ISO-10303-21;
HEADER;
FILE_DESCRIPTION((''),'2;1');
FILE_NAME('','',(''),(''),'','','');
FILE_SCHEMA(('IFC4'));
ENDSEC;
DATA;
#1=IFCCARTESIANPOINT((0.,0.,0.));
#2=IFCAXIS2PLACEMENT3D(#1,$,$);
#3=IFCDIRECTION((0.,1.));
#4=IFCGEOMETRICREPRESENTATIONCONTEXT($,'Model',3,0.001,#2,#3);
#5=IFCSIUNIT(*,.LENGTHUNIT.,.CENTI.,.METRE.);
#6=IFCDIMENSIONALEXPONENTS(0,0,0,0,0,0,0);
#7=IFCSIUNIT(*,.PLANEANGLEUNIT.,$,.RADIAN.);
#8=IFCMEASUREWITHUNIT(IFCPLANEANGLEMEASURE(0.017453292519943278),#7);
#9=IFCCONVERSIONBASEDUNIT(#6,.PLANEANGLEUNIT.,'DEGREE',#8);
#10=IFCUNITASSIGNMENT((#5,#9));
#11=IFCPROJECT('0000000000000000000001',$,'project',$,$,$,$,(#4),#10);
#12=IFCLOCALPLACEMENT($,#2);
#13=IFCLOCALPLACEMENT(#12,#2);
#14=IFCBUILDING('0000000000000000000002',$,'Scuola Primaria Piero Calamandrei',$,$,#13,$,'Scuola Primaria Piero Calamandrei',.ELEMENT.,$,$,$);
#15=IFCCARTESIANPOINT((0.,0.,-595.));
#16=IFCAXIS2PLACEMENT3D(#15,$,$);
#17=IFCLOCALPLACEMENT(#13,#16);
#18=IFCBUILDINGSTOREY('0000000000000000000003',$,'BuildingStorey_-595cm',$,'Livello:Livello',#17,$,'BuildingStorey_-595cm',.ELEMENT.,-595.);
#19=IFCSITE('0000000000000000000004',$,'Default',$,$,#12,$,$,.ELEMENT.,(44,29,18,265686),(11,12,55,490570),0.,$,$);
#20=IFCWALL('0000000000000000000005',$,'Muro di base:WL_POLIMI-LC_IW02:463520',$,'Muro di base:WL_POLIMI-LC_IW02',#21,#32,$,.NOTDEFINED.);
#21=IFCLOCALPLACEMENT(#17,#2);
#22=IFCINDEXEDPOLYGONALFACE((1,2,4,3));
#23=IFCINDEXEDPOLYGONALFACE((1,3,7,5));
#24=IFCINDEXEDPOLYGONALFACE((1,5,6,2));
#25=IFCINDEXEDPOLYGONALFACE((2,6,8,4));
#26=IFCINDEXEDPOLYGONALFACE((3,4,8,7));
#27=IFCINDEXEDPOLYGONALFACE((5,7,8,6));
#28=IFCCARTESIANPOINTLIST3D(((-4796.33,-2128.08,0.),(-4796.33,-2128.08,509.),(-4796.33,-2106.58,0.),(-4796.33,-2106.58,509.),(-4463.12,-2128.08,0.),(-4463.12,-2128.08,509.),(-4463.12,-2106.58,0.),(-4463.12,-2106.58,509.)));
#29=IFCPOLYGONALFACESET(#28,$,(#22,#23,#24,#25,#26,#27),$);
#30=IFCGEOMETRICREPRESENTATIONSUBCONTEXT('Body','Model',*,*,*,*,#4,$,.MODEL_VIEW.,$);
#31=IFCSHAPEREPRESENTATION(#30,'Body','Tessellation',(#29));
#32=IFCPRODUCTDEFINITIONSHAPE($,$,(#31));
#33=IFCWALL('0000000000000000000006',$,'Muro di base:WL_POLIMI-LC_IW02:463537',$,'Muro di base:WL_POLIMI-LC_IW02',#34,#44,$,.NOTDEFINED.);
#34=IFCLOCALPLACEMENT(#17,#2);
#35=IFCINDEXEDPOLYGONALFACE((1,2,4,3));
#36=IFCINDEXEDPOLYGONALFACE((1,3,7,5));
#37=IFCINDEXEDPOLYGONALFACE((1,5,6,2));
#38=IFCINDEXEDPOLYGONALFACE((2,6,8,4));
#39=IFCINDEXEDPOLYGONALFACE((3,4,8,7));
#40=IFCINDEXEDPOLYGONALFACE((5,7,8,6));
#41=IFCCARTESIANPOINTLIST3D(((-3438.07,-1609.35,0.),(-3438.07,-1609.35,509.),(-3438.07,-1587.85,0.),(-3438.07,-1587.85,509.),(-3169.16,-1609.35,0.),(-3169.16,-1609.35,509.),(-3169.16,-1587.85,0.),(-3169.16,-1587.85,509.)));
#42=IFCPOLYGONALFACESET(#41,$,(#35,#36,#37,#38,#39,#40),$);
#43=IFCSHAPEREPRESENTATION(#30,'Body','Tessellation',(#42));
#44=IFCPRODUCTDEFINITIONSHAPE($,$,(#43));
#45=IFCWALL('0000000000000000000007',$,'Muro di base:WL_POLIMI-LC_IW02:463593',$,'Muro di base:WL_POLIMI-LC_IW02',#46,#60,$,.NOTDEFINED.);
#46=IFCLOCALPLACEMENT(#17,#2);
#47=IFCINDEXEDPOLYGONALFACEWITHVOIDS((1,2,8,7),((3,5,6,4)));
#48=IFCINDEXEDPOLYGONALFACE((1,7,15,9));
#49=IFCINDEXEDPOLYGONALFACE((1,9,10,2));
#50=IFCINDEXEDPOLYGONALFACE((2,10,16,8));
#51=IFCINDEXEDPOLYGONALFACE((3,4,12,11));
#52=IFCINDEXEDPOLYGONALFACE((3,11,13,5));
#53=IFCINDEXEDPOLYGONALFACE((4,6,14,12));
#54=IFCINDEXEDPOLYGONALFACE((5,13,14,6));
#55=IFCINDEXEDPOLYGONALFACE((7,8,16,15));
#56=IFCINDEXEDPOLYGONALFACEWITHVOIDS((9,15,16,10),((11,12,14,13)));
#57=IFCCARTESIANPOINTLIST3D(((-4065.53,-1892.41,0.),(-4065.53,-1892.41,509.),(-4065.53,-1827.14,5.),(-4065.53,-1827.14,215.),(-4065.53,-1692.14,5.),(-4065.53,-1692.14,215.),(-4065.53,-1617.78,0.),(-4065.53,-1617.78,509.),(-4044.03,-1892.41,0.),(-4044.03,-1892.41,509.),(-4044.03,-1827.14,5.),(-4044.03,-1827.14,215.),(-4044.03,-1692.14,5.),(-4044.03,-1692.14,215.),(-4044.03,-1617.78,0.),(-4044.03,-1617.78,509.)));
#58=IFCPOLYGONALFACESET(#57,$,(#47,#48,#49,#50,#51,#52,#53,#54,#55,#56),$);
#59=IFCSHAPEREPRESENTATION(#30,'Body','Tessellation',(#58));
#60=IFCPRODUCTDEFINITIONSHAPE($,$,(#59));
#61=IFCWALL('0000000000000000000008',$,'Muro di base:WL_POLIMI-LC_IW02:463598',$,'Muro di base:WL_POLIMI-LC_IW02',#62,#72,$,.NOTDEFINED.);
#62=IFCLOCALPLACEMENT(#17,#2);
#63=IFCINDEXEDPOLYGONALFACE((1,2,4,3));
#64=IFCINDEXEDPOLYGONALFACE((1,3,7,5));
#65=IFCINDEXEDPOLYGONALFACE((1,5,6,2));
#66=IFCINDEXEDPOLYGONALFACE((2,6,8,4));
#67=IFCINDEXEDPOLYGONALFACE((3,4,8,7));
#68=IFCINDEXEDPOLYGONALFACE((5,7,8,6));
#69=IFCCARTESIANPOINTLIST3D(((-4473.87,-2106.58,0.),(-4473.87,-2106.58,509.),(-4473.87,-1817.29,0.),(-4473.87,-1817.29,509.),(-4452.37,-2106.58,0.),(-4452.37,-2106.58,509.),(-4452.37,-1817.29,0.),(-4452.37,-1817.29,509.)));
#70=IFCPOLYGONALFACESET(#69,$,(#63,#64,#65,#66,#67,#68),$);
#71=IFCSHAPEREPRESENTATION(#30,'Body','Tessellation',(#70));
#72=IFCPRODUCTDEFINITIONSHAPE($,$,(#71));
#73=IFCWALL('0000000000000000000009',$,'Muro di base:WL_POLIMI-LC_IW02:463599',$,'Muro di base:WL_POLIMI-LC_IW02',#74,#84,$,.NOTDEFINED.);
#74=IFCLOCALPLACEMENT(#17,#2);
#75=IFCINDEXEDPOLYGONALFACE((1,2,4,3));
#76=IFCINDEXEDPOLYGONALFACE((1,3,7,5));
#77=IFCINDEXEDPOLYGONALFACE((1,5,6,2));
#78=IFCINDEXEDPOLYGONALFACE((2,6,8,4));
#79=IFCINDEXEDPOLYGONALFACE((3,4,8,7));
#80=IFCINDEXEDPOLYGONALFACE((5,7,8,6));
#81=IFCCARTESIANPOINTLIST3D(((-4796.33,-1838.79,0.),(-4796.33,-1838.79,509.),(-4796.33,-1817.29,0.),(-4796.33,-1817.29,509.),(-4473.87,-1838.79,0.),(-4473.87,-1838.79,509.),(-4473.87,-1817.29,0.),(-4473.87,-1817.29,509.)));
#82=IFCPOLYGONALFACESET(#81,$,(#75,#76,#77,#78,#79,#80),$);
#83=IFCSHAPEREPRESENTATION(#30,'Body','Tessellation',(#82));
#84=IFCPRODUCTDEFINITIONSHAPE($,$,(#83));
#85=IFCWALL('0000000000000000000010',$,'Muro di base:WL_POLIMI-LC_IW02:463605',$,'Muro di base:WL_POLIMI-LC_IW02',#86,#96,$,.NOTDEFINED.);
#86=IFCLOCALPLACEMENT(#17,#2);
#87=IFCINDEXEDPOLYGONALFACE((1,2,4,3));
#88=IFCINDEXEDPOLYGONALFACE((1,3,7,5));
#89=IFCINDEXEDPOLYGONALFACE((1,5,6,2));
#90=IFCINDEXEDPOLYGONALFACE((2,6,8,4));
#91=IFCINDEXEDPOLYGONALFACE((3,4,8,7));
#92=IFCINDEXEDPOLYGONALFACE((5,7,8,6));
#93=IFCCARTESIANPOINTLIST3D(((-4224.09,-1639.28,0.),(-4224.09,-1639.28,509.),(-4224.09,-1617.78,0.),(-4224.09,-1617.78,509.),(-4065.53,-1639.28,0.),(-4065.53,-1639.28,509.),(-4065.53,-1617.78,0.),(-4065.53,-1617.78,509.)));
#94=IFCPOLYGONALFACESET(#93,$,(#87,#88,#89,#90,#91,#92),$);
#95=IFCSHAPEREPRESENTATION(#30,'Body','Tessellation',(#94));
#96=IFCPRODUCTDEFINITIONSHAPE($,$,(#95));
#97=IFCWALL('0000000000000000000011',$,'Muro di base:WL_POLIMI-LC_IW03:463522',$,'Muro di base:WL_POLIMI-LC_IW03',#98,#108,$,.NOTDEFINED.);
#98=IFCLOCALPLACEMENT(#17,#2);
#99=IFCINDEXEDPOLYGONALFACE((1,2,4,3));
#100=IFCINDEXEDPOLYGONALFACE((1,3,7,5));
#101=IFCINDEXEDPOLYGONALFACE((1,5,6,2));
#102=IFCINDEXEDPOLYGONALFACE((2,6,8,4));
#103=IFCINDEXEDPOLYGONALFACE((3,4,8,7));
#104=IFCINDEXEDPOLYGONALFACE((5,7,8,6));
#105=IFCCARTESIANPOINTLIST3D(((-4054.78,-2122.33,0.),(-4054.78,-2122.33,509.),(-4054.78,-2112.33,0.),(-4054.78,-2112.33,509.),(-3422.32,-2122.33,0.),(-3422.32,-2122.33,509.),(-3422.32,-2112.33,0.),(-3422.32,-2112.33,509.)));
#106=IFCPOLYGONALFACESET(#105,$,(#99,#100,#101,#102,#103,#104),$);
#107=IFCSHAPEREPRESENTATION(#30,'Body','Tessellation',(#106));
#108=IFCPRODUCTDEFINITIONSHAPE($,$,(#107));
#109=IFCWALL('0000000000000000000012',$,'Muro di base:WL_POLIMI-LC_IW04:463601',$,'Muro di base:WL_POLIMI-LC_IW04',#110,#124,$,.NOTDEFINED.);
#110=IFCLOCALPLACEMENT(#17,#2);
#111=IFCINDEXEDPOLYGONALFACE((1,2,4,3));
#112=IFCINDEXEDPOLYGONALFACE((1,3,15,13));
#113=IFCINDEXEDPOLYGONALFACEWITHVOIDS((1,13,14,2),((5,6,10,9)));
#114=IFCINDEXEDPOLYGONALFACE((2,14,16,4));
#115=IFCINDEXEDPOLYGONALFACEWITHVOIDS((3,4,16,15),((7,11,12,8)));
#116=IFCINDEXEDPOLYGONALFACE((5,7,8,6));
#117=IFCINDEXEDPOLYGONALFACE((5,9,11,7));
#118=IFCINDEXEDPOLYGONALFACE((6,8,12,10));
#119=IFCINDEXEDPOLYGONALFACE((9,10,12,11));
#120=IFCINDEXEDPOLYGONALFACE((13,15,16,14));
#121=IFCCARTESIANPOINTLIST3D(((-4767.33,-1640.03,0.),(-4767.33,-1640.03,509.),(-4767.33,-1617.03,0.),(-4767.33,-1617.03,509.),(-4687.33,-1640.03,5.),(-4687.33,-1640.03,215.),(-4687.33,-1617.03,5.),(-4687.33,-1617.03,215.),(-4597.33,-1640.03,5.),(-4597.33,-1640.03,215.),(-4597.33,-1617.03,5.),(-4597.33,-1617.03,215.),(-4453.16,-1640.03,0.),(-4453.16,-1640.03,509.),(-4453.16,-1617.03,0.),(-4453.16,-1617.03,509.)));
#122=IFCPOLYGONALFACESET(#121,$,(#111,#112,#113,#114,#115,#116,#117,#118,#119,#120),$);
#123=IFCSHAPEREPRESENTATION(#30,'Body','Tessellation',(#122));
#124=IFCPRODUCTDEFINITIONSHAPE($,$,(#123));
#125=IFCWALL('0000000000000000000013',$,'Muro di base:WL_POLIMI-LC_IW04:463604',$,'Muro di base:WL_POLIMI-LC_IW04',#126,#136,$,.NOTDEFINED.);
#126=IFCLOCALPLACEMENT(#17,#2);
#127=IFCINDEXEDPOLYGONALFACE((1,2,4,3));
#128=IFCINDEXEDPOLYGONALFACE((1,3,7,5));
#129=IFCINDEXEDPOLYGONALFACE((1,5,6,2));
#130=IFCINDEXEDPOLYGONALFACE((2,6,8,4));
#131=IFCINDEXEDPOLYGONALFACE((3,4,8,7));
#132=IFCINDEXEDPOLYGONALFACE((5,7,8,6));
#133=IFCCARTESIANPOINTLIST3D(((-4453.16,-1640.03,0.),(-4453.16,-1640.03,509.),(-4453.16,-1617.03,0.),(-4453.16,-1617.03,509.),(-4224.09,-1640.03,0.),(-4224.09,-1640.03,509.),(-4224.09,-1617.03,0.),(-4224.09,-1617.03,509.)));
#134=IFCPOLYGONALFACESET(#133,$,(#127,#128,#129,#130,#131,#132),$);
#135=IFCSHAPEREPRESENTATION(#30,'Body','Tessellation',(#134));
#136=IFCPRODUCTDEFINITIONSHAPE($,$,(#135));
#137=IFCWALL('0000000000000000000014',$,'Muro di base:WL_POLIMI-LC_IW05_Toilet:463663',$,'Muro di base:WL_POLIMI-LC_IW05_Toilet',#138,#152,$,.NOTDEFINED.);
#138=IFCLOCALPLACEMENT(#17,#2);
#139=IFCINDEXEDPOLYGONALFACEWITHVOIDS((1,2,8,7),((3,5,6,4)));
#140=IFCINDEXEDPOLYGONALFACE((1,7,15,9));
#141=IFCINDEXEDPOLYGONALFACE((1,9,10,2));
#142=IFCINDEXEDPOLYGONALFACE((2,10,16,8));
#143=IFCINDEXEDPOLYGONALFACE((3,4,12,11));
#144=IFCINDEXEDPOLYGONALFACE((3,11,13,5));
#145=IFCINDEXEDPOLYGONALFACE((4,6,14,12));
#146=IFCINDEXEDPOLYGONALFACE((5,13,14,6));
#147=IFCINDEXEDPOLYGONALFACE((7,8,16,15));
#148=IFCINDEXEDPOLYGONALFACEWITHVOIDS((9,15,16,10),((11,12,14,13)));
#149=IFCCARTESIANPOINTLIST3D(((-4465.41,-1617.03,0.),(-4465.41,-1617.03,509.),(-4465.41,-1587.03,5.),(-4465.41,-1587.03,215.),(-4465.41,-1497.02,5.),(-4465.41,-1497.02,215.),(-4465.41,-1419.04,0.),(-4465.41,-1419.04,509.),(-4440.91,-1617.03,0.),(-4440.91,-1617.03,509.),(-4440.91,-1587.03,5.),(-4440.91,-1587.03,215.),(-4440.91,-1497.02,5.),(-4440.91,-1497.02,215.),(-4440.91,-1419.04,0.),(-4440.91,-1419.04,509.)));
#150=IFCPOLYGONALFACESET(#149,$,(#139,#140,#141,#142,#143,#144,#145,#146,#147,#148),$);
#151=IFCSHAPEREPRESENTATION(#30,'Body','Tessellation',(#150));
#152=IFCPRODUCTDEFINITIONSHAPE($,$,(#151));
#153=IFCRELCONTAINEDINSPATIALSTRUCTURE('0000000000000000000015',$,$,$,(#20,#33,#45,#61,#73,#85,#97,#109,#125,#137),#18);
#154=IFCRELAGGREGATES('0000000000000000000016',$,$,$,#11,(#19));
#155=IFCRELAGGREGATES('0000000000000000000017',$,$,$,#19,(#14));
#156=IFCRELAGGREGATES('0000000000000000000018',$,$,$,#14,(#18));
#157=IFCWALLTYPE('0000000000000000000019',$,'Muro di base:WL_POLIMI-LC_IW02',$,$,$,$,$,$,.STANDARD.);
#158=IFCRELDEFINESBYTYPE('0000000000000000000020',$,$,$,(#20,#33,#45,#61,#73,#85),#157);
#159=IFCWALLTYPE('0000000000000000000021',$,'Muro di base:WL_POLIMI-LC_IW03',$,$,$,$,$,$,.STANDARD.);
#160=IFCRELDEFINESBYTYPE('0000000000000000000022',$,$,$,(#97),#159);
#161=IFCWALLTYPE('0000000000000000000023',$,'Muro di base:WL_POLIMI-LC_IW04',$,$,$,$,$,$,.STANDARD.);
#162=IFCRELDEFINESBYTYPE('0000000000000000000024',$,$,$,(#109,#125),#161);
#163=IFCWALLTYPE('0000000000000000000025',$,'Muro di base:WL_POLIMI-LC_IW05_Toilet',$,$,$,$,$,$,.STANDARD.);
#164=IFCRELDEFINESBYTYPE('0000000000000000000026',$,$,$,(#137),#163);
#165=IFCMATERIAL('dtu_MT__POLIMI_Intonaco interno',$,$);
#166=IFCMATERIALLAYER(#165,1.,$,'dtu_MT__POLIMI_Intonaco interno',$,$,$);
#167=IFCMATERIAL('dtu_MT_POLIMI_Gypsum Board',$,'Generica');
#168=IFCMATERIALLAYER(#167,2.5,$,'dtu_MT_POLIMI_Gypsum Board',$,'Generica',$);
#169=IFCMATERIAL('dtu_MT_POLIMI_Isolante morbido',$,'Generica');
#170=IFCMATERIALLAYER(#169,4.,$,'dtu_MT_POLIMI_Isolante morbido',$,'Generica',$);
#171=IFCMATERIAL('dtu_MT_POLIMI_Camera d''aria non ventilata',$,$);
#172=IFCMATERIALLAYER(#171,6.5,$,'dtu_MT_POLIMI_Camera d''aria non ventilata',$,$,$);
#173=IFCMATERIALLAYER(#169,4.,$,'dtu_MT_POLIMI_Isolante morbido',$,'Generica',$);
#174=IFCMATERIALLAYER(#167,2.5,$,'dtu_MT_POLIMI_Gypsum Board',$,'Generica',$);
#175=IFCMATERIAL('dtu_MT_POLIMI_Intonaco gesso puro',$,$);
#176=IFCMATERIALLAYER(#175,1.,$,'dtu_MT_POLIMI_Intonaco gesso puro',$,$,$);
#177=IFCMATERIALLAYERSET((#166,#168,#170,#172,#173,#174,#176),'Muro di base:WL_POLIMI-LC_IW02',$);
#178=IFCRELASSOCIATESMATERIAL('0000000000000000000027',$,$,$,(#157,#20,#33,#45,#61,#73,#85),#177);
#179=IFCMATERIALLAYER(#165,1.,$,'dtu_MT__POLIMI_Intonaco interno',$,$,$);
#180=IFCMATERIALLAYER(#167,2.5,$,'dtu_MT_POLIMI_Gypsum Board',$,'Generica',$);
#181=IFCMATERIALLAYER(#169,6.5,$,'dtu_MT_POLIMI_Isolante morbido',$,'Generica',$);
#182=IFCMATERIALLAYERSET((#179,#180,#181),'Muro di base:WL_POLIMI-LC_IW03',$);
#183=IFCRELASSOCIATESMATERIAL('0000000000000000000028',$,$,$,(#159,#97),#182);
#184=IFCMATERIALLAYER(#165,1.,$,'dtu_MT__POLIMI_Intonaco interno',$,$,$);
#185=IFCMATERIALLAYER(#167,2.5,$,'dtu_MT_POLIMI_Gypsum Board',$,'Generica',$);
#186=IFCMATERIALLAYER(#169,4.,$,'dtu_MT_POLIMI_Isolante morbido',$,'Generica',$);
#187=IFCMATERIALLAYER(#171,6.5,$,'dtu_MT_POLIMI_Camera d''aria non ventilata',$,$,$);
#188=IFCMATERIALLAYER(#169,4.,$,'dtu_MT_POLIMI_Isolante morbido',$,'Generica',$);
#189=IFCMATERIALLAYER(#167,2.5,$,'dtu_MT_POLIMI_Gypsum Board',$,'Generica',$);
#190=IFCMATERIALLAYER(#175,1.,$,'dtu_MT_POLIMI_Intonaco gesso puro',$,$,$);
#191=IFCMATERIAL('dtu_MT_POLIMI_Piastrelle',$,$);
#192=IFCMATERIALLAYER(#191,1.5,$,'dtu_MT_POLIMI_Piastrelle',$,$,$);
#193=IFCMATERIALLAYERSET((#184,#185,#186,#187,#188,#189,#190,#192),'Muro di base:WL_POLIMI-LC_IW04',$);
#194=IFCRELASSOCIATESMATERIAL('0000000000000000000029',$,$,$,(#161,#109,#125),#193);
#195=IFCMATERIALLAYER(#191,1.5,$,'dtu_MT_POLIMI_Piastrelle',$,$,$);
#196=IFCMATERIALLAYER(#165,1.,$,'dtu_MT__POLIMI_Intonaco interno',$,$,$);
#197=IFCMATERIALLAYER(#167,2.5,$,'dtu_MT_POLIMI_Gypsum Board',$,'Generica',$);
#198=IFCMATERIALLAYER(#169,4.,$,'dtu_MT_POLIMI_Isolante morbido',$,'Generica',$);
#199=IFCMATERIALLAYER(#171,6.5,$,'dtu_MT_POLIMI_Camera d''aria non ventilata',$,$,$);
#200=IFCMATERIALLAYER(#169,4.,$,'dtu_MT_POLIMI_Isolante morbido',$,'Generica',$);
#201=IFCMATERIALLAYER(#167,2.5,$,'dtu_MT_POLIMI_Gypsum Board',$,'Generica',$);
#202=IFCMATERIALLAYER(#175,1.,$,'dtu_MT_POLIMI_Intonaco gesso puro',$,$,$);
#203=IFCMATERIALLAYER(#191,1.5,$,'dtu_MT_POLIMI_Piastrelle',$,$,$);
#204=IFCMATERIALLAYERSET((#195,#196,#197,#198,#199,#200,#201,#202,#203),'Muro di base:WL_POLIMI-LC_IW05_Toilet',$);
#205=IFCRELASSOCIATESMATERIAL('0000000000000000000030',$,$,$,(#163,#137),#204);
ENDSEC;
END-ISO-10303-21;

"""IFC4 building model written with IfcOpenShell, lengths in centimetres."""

from ifc_helpers import new_model, entity, si_unit, converted_unit, direction, frame, frame_2d, origin, place, context, subcontext, project, spatial, rectangle, extrude, material, layer, layer_set, layer_usage, type_object, element, save


model = new_model("IFC4")

# Units and contexts
model_context = context("Model", 3, precision=0.001, world=origin(), true_north=direction((0.0, 1.0)))
body_context = subcontext(model_context, "Body", "Model", "MODEL_VIEW")
ifc_project = project(units=[si_unit("LENGTHUNIT", "METRE", prefix="CENTI"), converted_unit("PLANEANGLEUNIT", "DEGREE", entity("IfcPlaneAngleMeasure", 0.017453292519943278), si_unit("PLANEANGLEUNIT", "RADIAN"), dimensions=[0, 0, 0, 0, 0, 0, 0])], contexts=[model_context])

# Site, building, storey
site_placement = place(None, origin())
site = spatial("IfcSite", under=ifc_project, at=site_placement, Name="Default", CompositionType="ELEMENT", RefLatitude=(44, 29, 18, 265686), RefLongitude=(11, 12, 55, 490570), RefElevation=0.0)
building_placement = place(site_placement, origin())
building = spatial("IfcBuilding", under=site, at=building_placement, Name="Scuola Primaria Piero Calamandrei", LongName="Scuola Primaria Piero Calamandrei", CompositionType="ELEMENT")
storey_placement = place(building_placement, frame((0.0, 0.0, -595.0)))
storey = spatial("IfcBuildingStorey", under=building, at=storey_placement, Name="BuildingStorey_-595cm", ObjectType="Livello:Livello", LongName="BuildingStorey_-595cm", CompositionType="ELEMENT", Elevation=-595.0)

# Shared definitions
ifc_material_1 = material(Name="dtu_MT__POLIMI_Intonaco interno")

# Shared definitions
ifc_layer_1 = layer(ifc_material_1, 1.0, Name="dtu_MT__POLIMI_Intonaco interno")
ifc_material_2 = material(Name="dtu_MT_POLIMI_Gypsum Board", Category="Generica")
ifc_layer_2 = layer(ifc_material_2, 2.5, Name="dtu_MT_POLIMI_Gypsum Board", Category="Generica")
ifc_material_3 = material(Name="dtu_MT_POLIMI_Isolante morbido", Category="Generica")
ifc_layer_3 = layer(ifc_material_3, 4.0, Name="dtu_MT_POLIMI_Isolante morbido", Category="Generica")
ifc_material_4 = material(Name="dtu_MT_POLIMI_Camera d'aria non ventilata")
ifc_layer_4 = layer(ifc_material_4, 6.5, Name="dtu_MT_POLIMI_Camera d'aria non ventilata")
ifc_layer_5 = layer(ifc_material_3, 4.0, Name="dtu_MT_POLIMI_Isolante morbido", Category="Generica")
ifc_layer_6 = layer(ifc_material_2, 2.5, Name="dtu_MT_POLIMI_Gypsum Board", Category="Generica")
ifc_material_5 = material(Name="dtu_MT_POLIMI_Intonaco gesso puro")
ifc_layer_7 = layer(ifc_material_5, 1.0, Name="dtu_MT_POLIMI_Intonaco gesso puro")
ifc_layer_set_1 = layer_set([ifc_layer_1, ifc_layer_2, ifc_layer_3, ifc_layer_4, ifc_layer_5, ifc_layer_6, ifc_layer_7], Name="Muro di base:WL_POLIMI-LC_IW02")
wall_type_1 = type_object("IfcWallType", Name="Muro di base:WL_POLIMI-LC_IW02", PredefinedType="STANDARD", material=ifc_layer_set_1)

# Walls
ifc_layer_usage_1 = layer_usage(ifc_layer_set_1, "AXIS2", "NEGATIVE", 10.75)
wall_1_placement = place(storey_placement, frame((-4796.33, -2117.33, 0.0)))
element("IfcWall", 1, at=wall_1_placement, inside=storey, type_object=wall_type_1, material=ifc_layer_usage_1, Name="Muro di base:WL_POLIMI-LC_IW02:463520", ObjectType="Muro di base:WL_POLIMI-LC_IW02", PredefinedType="NOTDEFINED", context=body_context, shape_type="SweptSolid", body=[
    extrude(rectangle(XDim=333.21, YDim=21.5, at=frame_2d((166.6, 0.0), x_axis=(-1.0, 0.0))), origin(), (0.0, 0.0, 1.0), 509.0),
])
ifc_layer_usage_2 = layer_usage(ifc_layer_set_1, "AXIS2", "NEGATIVE", 10.75)
wall_2_placement = place(storey_placement, frame((-3438.07, -1598.6, 0.0)))
element("IfcWall", 2, at=wall_2_placement, inside=storey, type_object=wall_type_1, material=ifc_layer_usage_2, Name="Muro di base:WL_POLIMI-LC_IW02:463537", ObjectType="Muro di base:WL_POLIMI-LC_IW02", PredefinedType="NOTDEFINED", context=body_context, shape_type="SweptSolid", body=[
    extrude(rectangle(XDim=268.91, YDim=21.5, at=frame_2d((134.45, 0.0), x_axis=(-1.0, 0.0))), origin(), (0.0, 0.0, 1.0), 509.0),
])

# Wall, opening
ifc_layer_usage_3 = layer_usage(ifc_layer_set_1, "AXIS2", "NEGATIVE", 10.75)
wall_3_placement = place(storey_placement, frame((-4054.78, -1617.78, 0.0), z_axis=(0.0, 0.0, 1.0), x_axis=(0.0, -1.0, 0.0)))
wall_3 = element("IfcWall", 3, at=wall_3_placement, inside=storey, type_object=wall_type_1, material=ifc_layer_usage_3, Name="Muro di base:WL_POLIMI-LC_IW02:463593", ObjectType="Muro di base:WL_POLIMI-LC_IW02", PredefinedType="NOTDEFINED", context=body_context, shape_type="SweptSolid", body=[
    extrude(rectangle(XDim=274.64, YDim=21.5, at=frame_2d((137.32, 0.0), x_axis=(-1.0, 0.0))), origin(), (0.0, 0.0, 1.0), 509.0),
])
opening_1_placement = place(wall_3_placement, frame((74.37, -10.75, 5.0)))
element("IfcOpeningElement", 4, at=opening_1_placement, cuts=wall_3, PredefinedType="OPENING", context=body_context, shape_type="SweptSolid", body=[
    extrude(rectangle(XDim=210.0, YDim=135.0, at=frame_2d((105.0, 67.5), x_axis=(-1.0, 0.0))), frame((0.0, 0.0, 0.0), z_axis=(0.0, 1.0, 0.0), x_axis=(0.0, 0.0, 1.0)), (0.0, 0.0, 1.0), 21.5),
])

# Walls
ifc_layer_usage_4 = layer_usage(ifc_layer_set_1, "AXIS2", "NEGATIVE", 10.75)
wall_4_placement = place(storey_placement, frame((-4463.12, -2106.58, 0.0), z_axis=(0.0, 0.0, 1.0), x_axis=(0.0, 1.0, 0.0)))
element("IfcWall", 5, at=wall_4_placement, inside=storey, type_object=wall_type_1, material=ifc_layer_usage_4, Name="Muro di base:WL_POLIMI-LC_IW02:463598", ObjectType="Muro di base:WL_POLIMI-LC_IW02", PredefinedType="NOTDEFINED", context=body_context, shape_type="SweptSolid", body=[
    extrude(rectangle(XDim=289.29, YDim=21.5, at=frame_2d((144.65, 0.0), x_axis=(-1.0, 0.0))), origin(), (0.0, 0.0, 1.0), 509.0),
])
ifc_layer_usage_5 = layer_usage(ifc_layer_set_1, "AXIS2", "NEGATIVE", 10.75)
wall_5_placement = place(storey_placement, frame((-4473.87, -1828.04, 0.0), z_axis=(0.0, 0.0, 1.0), x_axis=(-1.0, 0.0, 0.0)))
element("IfcWall", 6, at=wall_5_placement, inside=storey, type_object=wall_type_1, material=ifc_layer_usage_5, Name="Muro di base:WL_POLIMI-LC_IW02:463599", ObjectType="Muro di base:WL_POLIMI-LC_IW02", PredefinedType="NOTDEFINED", context=body_context, shape_type="SweptSolid", body=[
    extrude(rectangle(XDim=322.46, YDim=21.5, at=frame_2d((161.23, 0.0), x_axis=(-1.0, 0.0))), origin(), (0.0, 0.0, 1.0), 509.0),
])
ifc_layer_usage_6 = layer_usage(ifc_layer_set_1, "AXIS2", "NEGATIVE", 10.75)
wall_6_placement = place(storey_placement, frame((-4224.09, -1628.53, 0.0)))
element("IfcWall", 7, at=wall_6_placement, inside=storey, type_object=wall_type_1, material=ifc_layer_usage_6, Name="Muro di base:WL_POLIMI-LC_IW02:463605", ObjectType="Muro di base:WL_POLIMI-LC_IW02", PredefinedType="NOTDEFINED", context=body_context, shape_type="SweptSolid", body=[
    extrude(rectangle(XDim=158.56, YDim=21.5, at=frame_2d((79.28, 0.0), x_axis=(-1.0, 0.0))), origin(), (0.0, 0.0, 1.0), 509.0),
])
ifc_layer_8 = layer(ifc_material_1, 1.0, Name="dtu_MT__POLIMI_Intonaco interno")
ifc_layer_9 = layer(ifc_material_2, 2.5, Name="dtu_MT_POLIMI_Gypsum Board", Category="Generica")
ifc_layer_10 = layer(ifc_material_3, 6.5, Name="dtu_MT_POLIMI_Isolante morbido", Category="Generica")
ifc_layer_set_2 = layer_set([ifc_layer_8, ifc_layer_9, ifc_layer_10], Name="Muro di base:WL_POLIMI-LC_IW03")
ifc_layer_usage_7 = layer_usage(ifc_layer_set_2, "AXIS2", "NEGATIVE", 5.0)
wall_type_2 = type_object("IfcWallType", Name="Muro di base:WL_POLIMI-LC_IW03", PredefinedType="STANDARD", material=ifc_layer_set_2)
wall_7_placement = place(storey_placement, frame((-4054.78, -2117.33, 0.0)))
element("IfcWall", 8, at=wall_7_placement, inside=storey, type_object=wall_type_2, material=ifc_layer_usage_7, Name="Muro di base:WL_POLIMI-LC_IW03:463522", ObjectType="Muro di base:WL_POLIMI-LC_IW03", PredefinedType="NOTDEFINED", context=body_context, shape_type="SweptSolid", body=[
    extrude(rectangle(XDim=632.46, YDim=10.0, at=frame_2d((316.23, 0.0), x_axis=(-1.0, 0.0))), origin(), (0.0, 0.0, 1.0), 509.0),
])

# Wall, opening
ifc_layer_11 = layer(ifc_material_1, 1.0, Name="dtu_MT__POLIMI_Intonaco interno")
ifc_layer_12 = layer(ifc_material_2, 2.5, Name="dtu_MT_POLIMI_Gypsum Board", Category="Generica")
ifc_layer_13 = layer(ifc_material_3, 4.0, Name="dtu_MT_POLIMI_Isolante morbido", Category="Generica")
ifc_layer_14 = layer(ifc_material_4, 6.5, Name="dtu_MT_POLIMI_Camera d'aria non ventilata")
ifc_layer_15 = layer(ifc_material_3, 4.0, Name="dtu_MT_POLIMI_Isolante morbido", Category="Generica")
ifc_layer_16 = layer(ifc_material_2, 2.5, Name="dtu_MT_POLIMI_Gypsum Board", Category="Generica")
ifc_layer_17 = layer(ifc_material_5, 1.0, Name="dtu_MT_POLIMI_Intonaco gesso puro")
ifc_material_6 = material(Name="dtu_MT_POLIMI_Piastrelle")
ifc_layer_18 = layer(ifc_material_6, 1.5, Name="dtu_MT_POLIMI_Piastrelle")
ifc_layer_set_3 = layer_set([ifc_layer_11, ifc_layer_12, ifc_layer_13, ifc_layer_14, ifc_layer_15, ifc_layer_16, ifc_layer_17, ifc_layer_18], Name="Muro di base:WL_POLIMI-LC_IW04")
ifc_layer_usage_8 = layer_usage(ifc_layer_set_3, "AXIS2", "NEGATIVE", 11.5)
wall_type_3 = type_object("IfcWallType", Name="Muro di base:WL_POLIMI-LC_IW04", PredefinedType="STANDARD", material=ifc_layer_set_3)
wall_8_placement = place(storey_placement, frame((-4767.33, -1628.53, 0.0)))
wall_8 = element("IfcWall", 9, at=wall_8_placement, inside=storey, type_object=wall_type_3, material=ifc_layer_usage_8, Name="Muro di base:WL_POLIMI-LC_IW04:463601", ObjectType="Muro di base:WL_POLIMI-LC_IW04", PredefinedType="NOTDEFINED", context=body_context, shape_type="SweptSolid", body=[
    extrude(rectangle(XDim=314.17, YDim=23.0, at=frame_2d((157.08, 0.0), x_axis=(-1.0, 0.0))), origin(), (0.0, 0.0, 1.0), 509.0),
])
opening_2_placement = place(wall_8_placement, frame((80.0, -11.5, 5.0)))
element("IfcOpeningElement", 10, at=opening_2_placement, cuts=wall_8, PredefinedType="OPENING", context=body_context, shape_type="SweptSolid", body=[
    extrude(rectangle(XDim=210.0, YDim=90.0, at=frame_2d((105.0, 45.0), x_axis=(1.0, 0.0))), frame((0.0, 0.0, 0.0), z_axis=(0.0, 1.0, 0.0), x_axis=(0.0, 0.0, 1.0)), (0.0, 0.0, 1.0), 23.0),
])

# Wall
ifc_layer_usage_9 = layer_usage(ifc_layer_set_3, "AXIS2", "NEGATIVE", 11.5)
wall_9_placement = place(storey_placement, frame((-4453.16, -1628.53, 0.0)))
element("IfcWall", 11, at=wall_9_placement, inside=storey, type_object=wall_type_3, material=ifc_layer_usage_9, Name="Muro di base:WL_POLIMI-LC_IW04:463604", ObjectType="Muro di base:WL_POLIMI-LC_IW04", PredefinedType="NOTDEFINED", context=body_context, shape_type="SweptSolid", body=[
    extrude(rectangle(XDim=229.07, YDim=23.0, at=frame_2d((114.54, 0.0), x_axis=(-1.0, 0.0))), origin(), (0.0, 0.0, 1.0), 509.0),
])

# Wall, opening
ifc_layer_19 = layer(ifc_material_6, 1.5, Name="dtu_MT_POLIMI_Piastrelle")
ifc_layer_20 = layer(ifc_material_1, 1.0, Name="dtu_MT__POLIMI_Intonaco interno")
ifc_layer_21 = layer(ifc_material_2, 2.5, Name="dtu_MT_POLIMI_Gypsum Board", Category="Generica")
ifc_layer_22 = layer(ifc_material_3, 4.0, Name="dtu_MT_POLIMI_Isolante morbido", Category="Generica")
ifc_layer_23 = layer(ifc_material_4, 6.5, Name="dtu_MT_POLIMI_Camera d'aria non ventilata")
ifc_layer_24 = layer(ifc_material_3, 4.0, Name="dtu_MT_POLIMI_Isolante morbido", Category="Generica")
ifc_layer_25 = layer(ifc_material_2, 2.5, Name="dtu_MT_POLIMI_Gypsum Board", Category="Generica")
ifc_layer_26 = layer(ifc_material_5, 1.0, Name="dtu_MT_POLIMI_Intonaco gesso puro")
ifc_layer_27 = layer(ifc_material_6, 1.5, Name="dtu_MT_POLIMI_Piastrelle")
ifc_layer_set_4 = layer_set([ifc_layer_19, ifc_layer_20, ifc_layer_21, ifc_layer_22, ifc_layer_23, ifc_layer_24, ifc_layer_25, ifc_layer_26, ifc_layer_27], Name="Muro di base:WL_POLIMI-LC_IW05_Toilet")
ifc_layer_usage_10 = layer_usage(ifc_layer_set_4, "AXIS2", "NEGATIVE", 12.25)
wall_type_4 = type_object("IfcWallType", Name="Muro di base:WL_POLIMI-LC_IW05_Toilet", PredefinedType="STANDARD", material=ifc_layer_set_4)
wall_10_placement = place(storey_placement, frame((-4453.16, -1419.04, 0.0), z_axis=(0.0, 0.0, 1.0), x_axis=(0.0, -1.0, 0.0)))
wall_10 = element("IfcWall", 12, at=wall_10_placement, inside=storey, type_object=wall_type_4, material=ifc_layer_usage_10, Name="Muro di base:WL_POLIMI-LC_IW05_Toilet:463663", ObjectType="Muro di base:WL_POLIMI-LC_IW05_Toilet", PredefinedType="NOTDEFINED", context=body_context, shape_type="SweptSolid", body=[
    extrude(rectangle(XDim=197.99, YDim=24.5, at=frame_2d((98.99, 0.0), x_axis=(-1.0, 0.0))), origin(), (0.0, 0.0, 1.0), 509.0),
])
opening_3_placement = place(wall_10_placement, frame((167.99, 12.25, 5.0)))
element("IfcOpeningElement", 13, at=opening_3_placement, cuts=wall_10, PredefinedType="OPENING", context=body_context, shape_type="SweptSolid", body=[
    extrude(rectangle(XDim=210.0, YDim=90.0, at=frame_2d((105.0, 45.0), x_axis=(1.0, 0.0))), frame((0.0, 0.0, 0.0), z_axis=(0.0, -1.0, 0.0), x_axis=(0.0, 0.0, 1.0)), (0.0, 0.0, 1.0), 24.5),
])

save(model, "model.ifc")
